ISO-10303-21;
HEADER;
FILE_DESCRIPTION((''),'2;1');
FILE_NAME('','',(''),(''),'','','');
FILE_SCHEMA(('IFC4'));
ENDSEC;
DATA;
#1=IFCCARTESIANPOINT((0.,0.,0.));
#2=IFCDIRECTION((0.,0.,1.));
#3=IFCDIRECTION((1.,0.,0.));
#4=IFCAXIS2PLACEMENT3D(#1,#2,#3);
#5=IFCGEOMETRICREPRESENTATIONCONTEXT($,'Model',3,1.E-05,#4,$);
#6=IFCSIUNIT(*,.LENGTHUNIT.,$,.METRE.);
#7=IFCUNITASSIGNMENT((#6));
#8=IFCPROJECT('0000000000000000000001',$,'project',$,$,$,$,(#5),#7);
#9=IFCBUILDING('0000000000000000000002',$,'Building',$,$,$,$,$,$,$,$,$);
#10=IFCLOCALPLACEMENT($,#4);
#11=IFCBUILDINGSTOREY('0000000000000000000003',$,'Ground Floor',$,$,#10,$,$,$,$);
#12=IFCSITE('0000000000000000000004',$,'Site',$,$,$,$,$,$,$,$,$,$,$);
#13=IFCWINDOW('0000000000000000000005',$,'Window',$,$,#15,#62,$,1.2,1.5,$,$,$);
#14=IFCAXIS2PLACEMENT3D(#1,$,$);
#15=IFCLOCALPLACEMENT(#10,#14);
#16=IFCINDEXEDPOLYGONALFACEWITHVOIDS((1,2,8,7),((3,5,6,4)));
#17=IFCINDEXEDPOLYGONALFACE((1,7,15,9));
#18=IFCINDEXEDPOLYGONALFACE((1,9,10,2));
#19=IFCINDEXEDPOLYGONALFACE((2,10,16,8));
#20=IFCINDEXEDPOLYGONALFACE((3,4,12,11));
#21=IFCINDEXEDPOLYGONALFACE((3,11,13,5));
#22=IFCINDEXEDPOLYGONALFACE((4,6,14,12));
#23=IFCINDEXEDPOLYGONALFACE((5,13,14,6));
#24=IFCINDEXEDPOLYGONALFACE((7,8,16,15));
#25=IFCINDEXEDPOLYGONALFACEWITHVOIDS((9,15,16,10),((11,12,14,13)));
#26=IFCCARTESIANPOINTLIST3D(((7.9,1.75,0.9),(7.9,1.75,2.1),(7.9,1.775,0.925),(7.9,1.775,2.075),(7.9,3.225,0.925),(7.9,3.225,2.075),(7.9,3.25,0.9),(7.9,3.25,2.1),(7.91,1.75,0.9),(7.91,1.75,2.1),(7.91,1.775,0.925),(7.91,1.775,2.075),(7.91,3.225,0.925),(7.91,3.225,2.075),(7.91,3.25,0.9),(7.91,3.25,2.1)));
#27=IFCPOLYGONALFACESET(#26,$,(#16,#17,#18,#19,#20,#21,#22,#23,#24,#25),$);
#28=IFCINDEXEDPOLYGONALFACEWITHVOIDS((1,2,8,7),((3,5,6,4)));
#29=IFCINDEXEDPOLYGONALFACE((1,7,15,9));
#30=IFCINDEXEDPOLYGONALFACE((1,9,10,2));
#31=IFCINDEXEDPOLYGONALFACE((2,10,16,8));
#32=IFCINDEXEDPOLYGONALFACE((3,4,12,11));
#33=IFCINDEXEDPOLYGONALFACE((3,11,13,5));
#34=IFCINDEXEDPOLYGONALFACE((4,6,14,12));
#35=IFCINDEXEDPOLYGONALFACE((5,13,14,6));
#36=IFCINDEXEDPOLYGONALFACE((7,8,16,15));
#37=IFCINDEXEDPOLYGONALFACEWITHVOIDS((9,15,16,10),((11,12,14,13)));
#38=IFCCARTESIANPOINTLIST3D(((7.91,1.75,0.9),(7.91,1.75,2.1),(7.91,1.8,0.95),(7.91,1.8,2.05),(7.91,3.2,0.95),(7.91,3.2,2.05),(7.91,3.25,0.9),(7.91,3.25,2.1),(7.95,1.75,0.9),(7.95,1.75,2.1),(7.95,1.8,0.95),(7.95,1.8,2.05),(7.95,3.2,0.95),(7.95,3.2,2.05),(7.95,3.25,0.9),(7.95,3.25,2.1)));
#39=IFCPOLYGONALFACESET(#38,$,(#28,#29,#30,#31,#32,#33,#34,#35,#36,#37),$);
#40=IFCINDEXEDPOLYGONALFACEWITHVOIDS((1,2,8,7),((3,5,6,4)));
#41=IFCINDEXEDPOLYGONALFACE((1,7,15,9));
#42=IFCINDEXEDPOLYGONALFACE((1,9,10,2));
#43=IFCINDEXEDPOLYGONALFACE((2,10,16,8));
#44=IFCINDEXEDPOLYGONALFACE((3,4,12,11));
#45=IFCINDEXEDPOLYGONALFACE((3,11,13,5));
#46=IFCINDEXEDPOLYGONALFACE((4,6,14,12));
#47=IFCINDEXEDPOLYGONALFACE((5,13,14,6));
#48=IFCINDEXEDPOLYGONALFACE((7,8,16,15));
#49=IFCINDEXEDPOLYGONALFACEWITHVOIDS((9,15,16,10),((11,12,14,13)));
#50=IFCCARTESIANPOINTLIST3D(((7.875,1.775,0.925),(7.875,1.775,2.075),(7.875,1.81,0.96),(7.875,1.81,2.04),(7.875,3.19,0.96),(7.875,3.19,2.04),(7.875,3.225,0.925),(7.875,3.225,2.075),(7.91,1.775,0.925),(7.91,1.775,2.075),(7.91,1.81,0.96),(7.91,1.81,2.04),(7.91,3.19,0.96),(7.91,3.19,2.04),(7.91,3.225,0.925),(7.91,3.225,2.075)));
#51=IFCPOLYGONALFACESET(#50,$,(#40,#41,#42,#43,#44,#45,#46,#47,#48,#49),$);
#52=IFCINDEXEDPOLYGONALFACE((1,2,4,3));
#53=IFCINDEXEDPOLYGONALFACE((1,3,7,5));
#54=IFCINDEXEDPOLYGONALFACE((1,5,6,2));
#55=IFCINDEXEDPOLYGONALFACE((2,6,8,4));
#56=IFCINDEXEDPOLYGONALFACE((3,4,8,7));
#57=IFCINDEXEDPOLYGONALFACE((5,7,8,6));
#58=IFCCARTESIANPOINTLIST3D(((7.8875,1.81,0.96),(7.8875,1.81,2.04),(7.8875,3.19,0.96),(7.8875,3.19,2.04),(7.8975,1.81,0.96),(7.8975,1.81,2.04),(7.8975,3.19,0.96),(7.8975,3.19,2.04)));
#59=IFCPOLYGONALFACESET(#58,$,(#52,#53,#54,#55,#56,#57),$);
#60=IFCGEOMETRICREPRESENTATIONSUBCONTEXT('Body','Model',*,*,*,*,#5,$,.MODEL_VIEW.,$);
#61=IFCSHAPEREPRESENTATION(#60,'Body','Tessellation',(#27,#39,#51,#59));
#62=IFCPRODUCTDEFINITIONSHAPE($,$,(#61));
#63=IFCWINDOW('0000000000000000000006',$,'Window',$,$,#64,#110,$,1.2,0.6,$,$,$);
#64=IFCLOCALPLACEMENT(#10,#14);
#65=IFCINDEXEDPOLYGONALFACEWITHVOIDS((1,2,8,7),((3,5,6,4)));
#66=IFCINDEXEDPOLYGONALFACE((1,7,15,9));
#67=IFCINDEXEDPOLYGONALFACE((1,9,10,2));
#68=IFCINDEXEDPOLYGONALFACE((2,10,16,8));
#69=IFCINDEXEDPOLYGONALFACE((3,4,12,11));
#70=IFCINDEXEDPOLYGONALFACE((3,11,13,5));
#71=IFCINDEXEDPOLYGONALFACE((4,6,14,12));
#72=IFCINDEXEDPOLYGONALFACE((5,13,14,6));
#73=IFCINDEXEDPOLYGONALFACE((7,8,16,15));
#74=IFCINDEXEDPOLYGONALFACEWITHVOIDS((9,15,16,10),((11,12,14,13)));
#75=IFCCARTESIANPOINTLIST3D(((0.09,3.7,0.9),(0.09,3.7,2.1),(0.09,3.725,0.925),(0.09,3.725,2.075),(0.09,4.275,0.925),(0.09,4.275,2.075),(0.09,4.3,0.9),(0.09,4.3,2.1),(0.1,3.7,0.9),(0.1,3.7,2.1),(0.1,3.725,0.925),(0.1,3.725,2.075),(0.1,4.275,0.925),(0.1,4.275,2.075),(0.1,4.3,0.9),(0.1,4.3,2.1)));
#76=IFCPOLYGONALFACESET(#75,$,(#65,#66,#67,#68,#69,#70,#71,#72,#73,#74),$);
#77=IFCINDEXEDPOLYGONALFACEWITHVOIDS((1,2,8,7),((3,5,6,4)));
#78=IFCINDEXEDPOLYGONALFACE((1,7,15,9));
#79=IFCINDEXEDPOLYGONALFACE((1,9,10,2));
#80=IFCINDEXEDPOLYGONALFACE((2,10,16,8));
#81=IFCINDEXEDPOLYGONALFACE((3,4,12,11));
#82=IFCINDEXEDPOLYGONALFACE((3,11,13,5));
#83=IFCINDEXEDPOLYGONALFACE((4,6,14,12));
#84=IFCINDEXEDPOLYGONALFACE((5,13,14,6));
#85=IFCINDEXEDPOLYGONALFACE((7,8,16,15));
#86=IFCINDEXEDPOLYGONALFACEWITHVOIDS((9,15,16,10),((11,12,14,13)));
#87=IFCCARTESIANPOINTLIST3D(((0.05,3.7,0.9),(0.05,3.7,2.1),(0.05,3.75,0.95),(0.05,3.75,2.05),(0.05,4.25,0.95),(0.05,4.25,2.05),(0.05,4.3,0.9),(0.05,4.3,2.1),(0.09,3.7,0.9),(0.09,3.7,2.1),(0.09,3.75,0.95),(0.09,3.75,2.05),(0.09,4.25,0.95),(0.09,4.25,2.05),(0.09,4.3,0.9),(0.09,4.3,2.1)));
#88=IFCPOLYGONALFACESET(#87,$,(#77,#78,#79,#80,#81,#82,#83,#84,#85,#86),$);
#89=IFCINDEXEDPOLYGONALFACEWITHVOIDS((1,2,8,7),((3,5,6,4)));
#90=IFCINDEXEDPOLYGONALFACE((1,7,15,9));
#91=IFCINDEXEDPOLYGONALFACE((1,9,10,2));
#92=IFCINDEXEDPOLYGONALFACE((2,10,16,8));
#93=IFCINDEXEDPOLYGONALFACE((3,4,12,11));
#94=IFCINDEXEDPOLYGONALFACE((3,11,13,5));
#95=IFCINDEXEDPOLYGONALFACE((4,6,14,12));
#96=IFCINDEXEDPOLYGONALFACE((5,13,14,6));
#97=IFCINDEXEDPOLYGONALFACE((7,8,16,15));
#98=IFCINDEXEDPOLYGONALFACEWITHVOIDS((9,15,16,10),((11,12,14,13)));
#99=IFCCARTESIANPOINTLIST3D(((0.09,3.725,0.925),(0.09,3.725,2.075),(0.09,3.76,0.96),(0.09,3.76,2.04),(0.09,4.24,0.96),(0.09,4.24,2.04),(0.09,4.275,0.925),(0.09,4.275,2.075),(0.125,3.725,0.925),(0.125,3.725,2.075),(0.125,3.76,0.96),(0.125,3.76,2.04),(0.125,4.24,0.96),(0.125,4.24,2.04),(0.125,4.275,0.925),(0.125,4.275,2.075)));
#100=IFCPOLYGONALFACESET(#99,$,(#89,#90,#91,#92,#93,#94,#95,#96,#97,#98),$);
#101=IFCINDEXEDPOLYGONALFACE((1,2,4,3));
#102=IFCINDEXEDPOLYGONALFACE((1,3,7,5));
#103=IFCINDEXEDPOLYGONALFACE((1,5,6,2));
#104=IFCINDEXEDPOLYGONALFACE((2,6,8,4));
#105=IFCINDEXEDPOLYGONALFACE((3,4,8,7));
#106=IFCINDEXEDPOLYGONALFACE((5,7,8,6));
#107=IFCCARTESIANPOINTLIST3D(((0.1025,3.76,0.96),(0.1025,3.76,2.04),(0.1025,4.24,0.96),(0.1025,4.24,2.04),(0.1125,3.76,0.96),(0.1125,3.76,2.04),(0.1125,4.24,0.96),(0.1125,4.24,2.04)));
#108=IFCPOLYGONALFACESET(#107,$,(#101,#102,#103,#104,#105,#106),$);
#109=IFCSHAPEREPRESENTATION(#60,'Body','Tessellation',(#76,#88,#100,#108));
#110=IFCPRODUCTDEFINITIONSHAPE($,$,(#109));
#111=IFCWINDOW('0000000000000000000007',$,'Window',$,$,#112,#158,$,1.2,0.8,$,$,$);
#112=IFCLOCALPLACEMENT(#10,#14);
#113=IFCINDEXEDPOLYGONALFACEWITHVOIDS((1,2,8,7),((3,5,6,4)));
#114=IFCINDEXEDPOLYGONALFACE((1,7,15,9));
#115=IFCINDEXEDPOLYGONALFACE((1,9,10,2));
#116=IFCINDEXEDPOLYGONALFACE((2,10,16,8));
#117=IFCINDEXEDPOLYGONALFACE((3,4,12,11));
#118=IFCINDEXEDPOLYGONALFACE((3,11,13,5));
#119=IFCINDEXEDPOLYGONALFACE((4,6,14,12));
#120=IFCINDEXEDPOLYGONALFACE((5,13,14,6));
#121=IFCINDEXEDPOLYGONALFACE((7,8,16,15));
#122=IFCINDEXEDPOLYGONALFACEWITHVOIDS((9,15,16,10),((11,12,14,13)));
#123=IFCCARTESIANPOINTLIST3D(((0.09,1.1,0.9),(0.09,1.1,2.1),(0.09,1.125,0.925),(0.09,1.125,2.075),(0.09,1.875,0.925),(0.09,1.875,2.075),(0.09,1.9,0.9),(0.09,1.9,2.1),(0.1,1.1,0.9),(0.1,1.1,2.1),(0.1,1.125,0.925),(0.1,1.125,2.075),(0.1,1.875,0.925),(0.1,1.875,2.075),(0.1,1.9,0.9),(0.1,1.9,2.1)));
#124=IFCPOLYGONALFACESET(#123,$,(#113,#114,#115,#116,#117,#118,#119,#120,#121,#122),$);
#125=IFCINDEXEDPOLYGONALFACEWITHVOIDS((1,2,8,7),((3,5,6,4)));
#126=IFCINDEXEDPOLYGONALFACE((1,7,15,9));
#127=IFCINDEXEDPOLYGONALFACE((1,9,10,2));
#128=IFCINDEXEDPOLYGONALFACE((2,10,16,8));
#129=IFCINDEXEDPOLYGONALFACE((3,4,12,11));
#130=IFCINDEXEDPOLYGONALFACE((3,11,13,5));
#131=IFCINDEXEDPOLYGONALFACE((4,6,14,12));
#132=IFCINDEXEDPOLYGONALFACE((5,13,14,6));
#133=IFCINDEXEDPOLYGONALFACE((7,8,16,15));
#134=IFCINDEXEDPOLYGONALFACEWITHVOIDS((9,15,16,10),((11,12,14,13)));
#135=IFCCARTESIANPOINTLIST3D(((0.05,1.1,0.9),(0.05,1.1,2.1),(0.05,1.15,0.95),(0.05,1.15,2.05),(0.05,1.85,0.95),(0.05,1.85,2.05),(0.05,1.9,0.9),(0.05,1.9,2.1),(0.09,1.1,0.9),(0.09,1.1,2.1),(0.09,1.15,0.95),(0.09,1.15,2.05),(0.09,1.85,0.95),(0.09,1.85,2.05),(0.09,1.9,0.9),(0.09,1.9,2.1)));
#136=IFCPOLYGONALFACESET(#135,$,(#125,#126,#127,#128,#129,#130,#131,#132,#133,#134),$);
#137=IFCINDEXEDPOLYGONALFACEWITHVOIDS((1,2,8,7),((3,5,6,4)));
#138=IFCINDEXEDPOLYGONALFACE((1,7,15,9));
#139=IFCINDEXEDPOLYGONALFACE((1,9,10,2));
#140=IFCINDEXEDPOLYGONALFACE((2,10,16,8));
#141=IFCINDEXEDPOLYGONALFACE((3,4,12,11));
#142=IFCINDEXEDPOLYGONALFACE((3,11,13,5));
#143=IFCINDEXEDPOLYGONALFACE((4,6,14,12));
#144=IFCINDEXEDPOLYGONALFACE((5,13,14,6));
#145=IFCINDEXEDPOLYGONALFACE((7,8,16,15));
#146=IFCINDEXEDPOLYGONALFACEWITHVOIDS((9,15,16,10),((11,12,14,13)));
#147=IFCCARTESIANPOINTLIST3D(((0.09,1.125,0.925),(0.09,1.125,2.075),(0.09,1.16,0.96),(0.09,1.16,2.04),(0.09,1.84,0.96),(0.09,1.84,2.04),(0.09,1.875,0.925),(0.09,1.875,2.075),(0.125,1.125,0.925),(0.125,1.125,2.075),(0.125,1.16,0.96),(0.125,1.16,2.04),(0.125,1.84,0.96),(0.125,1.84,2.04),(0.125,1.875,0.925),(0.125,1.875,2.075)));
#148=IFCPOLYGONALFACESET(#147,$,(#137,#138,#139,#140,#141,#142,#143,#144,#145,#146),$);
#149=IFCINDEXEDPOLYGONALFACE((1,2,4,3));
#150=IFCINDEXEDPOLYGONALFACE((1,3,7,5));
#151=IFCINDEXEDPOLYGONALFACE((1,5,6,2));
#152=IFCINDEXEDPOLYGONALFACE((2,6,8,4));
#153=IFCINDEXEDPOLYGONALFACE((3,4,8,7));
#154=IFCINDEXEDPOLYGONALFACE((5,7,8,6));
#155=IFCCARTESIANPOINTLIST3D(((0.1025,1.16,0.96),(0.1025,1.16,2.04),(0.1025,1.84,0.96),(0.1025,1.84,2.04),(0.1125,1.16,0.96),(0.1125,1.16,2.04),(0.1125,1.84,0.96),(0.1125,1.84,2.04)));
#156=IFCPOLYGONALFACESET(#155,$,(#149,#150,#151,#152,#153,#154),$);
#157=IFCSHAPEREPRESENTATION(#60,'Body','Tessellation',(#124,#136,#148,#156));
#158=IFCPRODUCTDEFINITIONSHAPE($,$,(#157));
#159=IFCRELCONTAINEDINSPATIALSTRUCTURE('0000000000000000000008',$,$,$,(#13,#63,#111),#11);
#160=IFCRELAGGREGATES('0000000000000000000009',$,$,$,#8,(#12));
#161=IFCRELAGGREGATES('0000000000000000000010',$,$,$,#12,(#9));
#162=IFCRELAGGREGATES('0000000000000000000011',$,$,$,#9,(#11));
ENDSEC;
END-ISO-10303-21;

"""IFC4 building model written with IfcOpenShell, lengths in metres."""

from ifc_helpers import new_model, si_unit, frame, origin_with_axes, place, context, subcontext, project, spatial, line, indexed_curve, outline, extrude, element, save


model = new_model("IFC4")

# Units and contexts
model_context = context("Model", 3, precision=1e-05, world=origin_with_axes())
body_context = subcontext(model_context, "Body", "Model", "MODEL_VIEW")
ifc_project = project(units=[si_unit("LENGTHUNIT", "METRE")], contexts=[model_context])

# Site, building, storey
site = spatial("IfcSite", under=ifc_project, Name="Site")
building = spatial("IfcBuilding", under=site, Name="Building")
storey_placement = place(None, origin_with_axes())
storey = spatial("IfcBuildingStorey", under=building, at=storey_placement, Name="Ground Floor")

# Windows
for number, where, z_axis, x_axis, name in (
    (1, (8.0, 1.75, 0.9), (0.0, 0.0, 1.0), (0.0, 1.0, 0.0), "Window"),
):
    element("IfcWindow", number, at=place(storey_placement, frame(where, z_axis=z_axis, x_axis=x_axis)), inside=storey, Name=name, OverallHeight=1.2, OverallWidth=1.5, context=body_context, shape_type="SweptSolid", body=[
        extrude(outline(indexed_curve([(0.0, 0.0), (1.5, 0.0), (1.5, 1.2), (0.0, 1.2)], segments=[line(1, 2, 3, 4, 1)]), holes=[indexed_curve([(0.025, 0.025), (1.475, 0.025), (1.475, 1.175), (0.025, 1.175)], segments=[line(1, 2, 3, 4, 1)])]), frame((0.0, 0.09, 0.0), z_axis=(0.0, -1.0, 0.0), x_axis=(1.0, 0.0, 0.0)), (0.0, 0.0, -1.0), 0.01),
        extrude(outline(indexed_curve([(0.0, 0.0), (1.5, 0.0), (1.5, 1.2), (0.0, 1.2)], segments=[line(1, 2, 3, 4, 1)]), holes=[indexed_curve([(0.05, 0.05), (1.45, 0.05), (1.45, 1.15), (0.05, 1.15)], segments=[line(1, 2, 3, 4, 1)])]), frame((0.0, 0.05, 0.0), z_axis=(0.0, -1.0, 0.0), x_axis=(1.0, 0.0, 0.0)), (0.0, 0.0, -1.0), 0.04),
        extrude(outline(indexed_curve([(0.0, 0.0), (1.45, 0.0), (1.45, 1.15), (0.0, 1.15)], segments=[line(1, 2, 3, 4, 1)]), holes=[indexed_curve([(0.035, 0.035), (1.415, 0.035), (1.415, 1.115), (0.035, 1.115)], segments=[line(1, 2, 3, 4, 1)])]), frame((0.025, 0.09, 0.025), z_axis=(0.0, -1.0, 0.0), x_axis=(1.0, 0.0, 0.0)), (0.0, 0.0, -1.0), 0.035),
        extrude(outline(indexed_curve([(0.035, 0.035), (1.415, 0.035), (1.415, 1.115), (0.035, 1.115)], segments=[line(1, 2, 3, 4, 1)])), frame((0.025, 0.1025, 0.025), z_axis=(0.0, -1.0, 0.0), x_axis=(1.0, 0.0, 0.0)), (0.0, 0.0, -1.0), 0.01),
    ])
window_1_placement = place(storey_placement, frame((0.0, 4.3, 0.9), z_axis=(0.0, 0.0, 1.0), x_axis=(0.0, -1.0, 0.0)))
element("IfcWindow", 2, at=window_1_placement, inside=storey, Name="Window", OverallHeight=1.2, OverallWidth=0.6, context=body_context, shape_type="SweptSolid", body=[
    extrude(outline(indexed_curve([(0.0, 0.0), (0.6, 0.0), (0.6, 1.2), (0.0, 1.2)], segments=[line(1, 2, 3, 4, 1)]), holes=[indexed_curve([(0.025, 0.025), (0.575, 0.025), (0.575, 1.175), (0.025, 1.175)], segments=[line(1, 2, 3, 4, 1)])]), frame((0.0, 0.09, 0.0), z_axis=(0.0, -1.0, 0.0), x_axis=(1.0, 0.0, 0.0)), (0.0, 0.0, -1.0), 0.01),
    extrude(outline(indexed_curve([(0.0, 0.0), (0.6, 0.0), (0.6, 1.2), (0.0, 1.2)], segments=[line(1, 2, 3, 4, 1)]), holes=[indexed_curve([(0.05, 0.05), (0.55, 0.05), (0.55, 1.15), (0.05, 1.15)], segments=[line(1, 2, 3, 4, 1)])]), frame((0.0, 0.05, 0.0), z_axis=(0.0, -1.0, 0.0), x_axis=(1.0, 0.0, 0.0)), (0.0, 0.0, -1.0), 0.04),
    extrude(outline(indexed_curve([(0.0, 0.0), (0.55, 0.0), (0.55, 1.15), (0.0, 1.15)], segments=[line(1, 2, 3, 4, 1)]), holes=[indexed_curve([(0.035, 0.035), (0.515, 0.035), (0.515, 1.115), (0.035, 1.115)], segments=[line(1, 2, 3, 4, 1)])]), frame((0.025, 0.09, 0.025), z_axis=(0.0, -1.0, 0.0), x_axis=(1.0, 0.0, 0.0)), (0.0, 0.0, -1.0), 0.035),
    extrude(outline(indexed_curve([(0.035, 0.035), (0.515, 0.035), (0.515, 1.115), (0.035, 1.115)], segments=[line(1, 2, 3, 4, 1)])), frame((0.025, 0.1025, 0.025), z_axis=(0.0, -1.0, 0.0), x_axis=(1.0, 0.0, 0.0)), (0.0, 0.0, -1.0), 0.01),
])
window_2_placement = place(storey_placement, frame((0.0, 1.9, 0.9), z_axis=(0.0, 0.0, 1.0), x_axis=(0.0, -1.0, 0.0)))
element("IfcWindow", 3, at=window_2_placement, inside=storey, Name="Window", OverallHeight=1.2, OverallWidth=0.8, context=body_context, shape_type="SweptSolid", body=[
    extrude(outline(indexed_curve([(0.0, 0.0), (0.8, 0.0), (0.8, 1.2), (0.0, 1.2)], segments=[line(1, 2, 3, 4, 1)]), holes=[indexed_curve([(0.025, 0.025), (0.775, 0.025), (0.775, 1.175), (0.025, 1.175)], segments=[line(1, 2, 3, 4, 1)])]), frame((0.0, 0.09, 0.0), z_axis=(0.0, -1.0, 0.0), x_axis=(1.0, 0.0, 0.0)), (0.0, 0.0, -1.0), 0.01),
    extrude(outline(indexed_curve([(0.0, 0.0), (0.8, 0.0), (0.8, 1.2), (0.0, 1.2)], segments=[line(1, 2, 3, 4, 1)]), holes=[indexed_curve([(0.05, 0.05), (0.75, 0.05), (0.75, 1.15), (0.05, 1.15)], segments=[line(1, 2, 3, 4, 1)])]), frame((0.0, 0.05, 0.0), z_axis=(0.0, -1.0, 0.0), x_axis=(1.0, 0.0, 0.0)), (0.0, 0.0, -1.0), 0.04),
    extrude(outline(indexed_curve([(0.0, 0.0), (0.75, 0.0), (0.75, 1.15), (0.0, 1.15)], segments=[line(1, 2, 3, 4, 1)]), holes=[indexed_curve([(0.035, 0.035), (0.715, 0.035), (0.715, 1.115), (0.035, 1.115)], segments=[line(1, 2, 3, 4, 1)])]), frame((0.025, 0.09, 0.025), z_axis=(0.0, -1.0, 0.0), x_axis=(1.0, 0.0, 0.0)), (0.0, 0.0, -1.0), 0.035),
    extrude(outline(indexed_curve([(0.035, 0.035), (0.715, 0.035), (0.715, 1.115), (0.035, 1.115)], segments=[line(1, 2, 3, 4, 1)])), frame((0.025, 0.1025, 0.025), z_axis=(0.0, -1.0, 0.0), x_axis=(1.0, 0.0, 0.0)), (0.0, 0.0, -1.0), 0.01),
])

save(model, "model.ifc")
